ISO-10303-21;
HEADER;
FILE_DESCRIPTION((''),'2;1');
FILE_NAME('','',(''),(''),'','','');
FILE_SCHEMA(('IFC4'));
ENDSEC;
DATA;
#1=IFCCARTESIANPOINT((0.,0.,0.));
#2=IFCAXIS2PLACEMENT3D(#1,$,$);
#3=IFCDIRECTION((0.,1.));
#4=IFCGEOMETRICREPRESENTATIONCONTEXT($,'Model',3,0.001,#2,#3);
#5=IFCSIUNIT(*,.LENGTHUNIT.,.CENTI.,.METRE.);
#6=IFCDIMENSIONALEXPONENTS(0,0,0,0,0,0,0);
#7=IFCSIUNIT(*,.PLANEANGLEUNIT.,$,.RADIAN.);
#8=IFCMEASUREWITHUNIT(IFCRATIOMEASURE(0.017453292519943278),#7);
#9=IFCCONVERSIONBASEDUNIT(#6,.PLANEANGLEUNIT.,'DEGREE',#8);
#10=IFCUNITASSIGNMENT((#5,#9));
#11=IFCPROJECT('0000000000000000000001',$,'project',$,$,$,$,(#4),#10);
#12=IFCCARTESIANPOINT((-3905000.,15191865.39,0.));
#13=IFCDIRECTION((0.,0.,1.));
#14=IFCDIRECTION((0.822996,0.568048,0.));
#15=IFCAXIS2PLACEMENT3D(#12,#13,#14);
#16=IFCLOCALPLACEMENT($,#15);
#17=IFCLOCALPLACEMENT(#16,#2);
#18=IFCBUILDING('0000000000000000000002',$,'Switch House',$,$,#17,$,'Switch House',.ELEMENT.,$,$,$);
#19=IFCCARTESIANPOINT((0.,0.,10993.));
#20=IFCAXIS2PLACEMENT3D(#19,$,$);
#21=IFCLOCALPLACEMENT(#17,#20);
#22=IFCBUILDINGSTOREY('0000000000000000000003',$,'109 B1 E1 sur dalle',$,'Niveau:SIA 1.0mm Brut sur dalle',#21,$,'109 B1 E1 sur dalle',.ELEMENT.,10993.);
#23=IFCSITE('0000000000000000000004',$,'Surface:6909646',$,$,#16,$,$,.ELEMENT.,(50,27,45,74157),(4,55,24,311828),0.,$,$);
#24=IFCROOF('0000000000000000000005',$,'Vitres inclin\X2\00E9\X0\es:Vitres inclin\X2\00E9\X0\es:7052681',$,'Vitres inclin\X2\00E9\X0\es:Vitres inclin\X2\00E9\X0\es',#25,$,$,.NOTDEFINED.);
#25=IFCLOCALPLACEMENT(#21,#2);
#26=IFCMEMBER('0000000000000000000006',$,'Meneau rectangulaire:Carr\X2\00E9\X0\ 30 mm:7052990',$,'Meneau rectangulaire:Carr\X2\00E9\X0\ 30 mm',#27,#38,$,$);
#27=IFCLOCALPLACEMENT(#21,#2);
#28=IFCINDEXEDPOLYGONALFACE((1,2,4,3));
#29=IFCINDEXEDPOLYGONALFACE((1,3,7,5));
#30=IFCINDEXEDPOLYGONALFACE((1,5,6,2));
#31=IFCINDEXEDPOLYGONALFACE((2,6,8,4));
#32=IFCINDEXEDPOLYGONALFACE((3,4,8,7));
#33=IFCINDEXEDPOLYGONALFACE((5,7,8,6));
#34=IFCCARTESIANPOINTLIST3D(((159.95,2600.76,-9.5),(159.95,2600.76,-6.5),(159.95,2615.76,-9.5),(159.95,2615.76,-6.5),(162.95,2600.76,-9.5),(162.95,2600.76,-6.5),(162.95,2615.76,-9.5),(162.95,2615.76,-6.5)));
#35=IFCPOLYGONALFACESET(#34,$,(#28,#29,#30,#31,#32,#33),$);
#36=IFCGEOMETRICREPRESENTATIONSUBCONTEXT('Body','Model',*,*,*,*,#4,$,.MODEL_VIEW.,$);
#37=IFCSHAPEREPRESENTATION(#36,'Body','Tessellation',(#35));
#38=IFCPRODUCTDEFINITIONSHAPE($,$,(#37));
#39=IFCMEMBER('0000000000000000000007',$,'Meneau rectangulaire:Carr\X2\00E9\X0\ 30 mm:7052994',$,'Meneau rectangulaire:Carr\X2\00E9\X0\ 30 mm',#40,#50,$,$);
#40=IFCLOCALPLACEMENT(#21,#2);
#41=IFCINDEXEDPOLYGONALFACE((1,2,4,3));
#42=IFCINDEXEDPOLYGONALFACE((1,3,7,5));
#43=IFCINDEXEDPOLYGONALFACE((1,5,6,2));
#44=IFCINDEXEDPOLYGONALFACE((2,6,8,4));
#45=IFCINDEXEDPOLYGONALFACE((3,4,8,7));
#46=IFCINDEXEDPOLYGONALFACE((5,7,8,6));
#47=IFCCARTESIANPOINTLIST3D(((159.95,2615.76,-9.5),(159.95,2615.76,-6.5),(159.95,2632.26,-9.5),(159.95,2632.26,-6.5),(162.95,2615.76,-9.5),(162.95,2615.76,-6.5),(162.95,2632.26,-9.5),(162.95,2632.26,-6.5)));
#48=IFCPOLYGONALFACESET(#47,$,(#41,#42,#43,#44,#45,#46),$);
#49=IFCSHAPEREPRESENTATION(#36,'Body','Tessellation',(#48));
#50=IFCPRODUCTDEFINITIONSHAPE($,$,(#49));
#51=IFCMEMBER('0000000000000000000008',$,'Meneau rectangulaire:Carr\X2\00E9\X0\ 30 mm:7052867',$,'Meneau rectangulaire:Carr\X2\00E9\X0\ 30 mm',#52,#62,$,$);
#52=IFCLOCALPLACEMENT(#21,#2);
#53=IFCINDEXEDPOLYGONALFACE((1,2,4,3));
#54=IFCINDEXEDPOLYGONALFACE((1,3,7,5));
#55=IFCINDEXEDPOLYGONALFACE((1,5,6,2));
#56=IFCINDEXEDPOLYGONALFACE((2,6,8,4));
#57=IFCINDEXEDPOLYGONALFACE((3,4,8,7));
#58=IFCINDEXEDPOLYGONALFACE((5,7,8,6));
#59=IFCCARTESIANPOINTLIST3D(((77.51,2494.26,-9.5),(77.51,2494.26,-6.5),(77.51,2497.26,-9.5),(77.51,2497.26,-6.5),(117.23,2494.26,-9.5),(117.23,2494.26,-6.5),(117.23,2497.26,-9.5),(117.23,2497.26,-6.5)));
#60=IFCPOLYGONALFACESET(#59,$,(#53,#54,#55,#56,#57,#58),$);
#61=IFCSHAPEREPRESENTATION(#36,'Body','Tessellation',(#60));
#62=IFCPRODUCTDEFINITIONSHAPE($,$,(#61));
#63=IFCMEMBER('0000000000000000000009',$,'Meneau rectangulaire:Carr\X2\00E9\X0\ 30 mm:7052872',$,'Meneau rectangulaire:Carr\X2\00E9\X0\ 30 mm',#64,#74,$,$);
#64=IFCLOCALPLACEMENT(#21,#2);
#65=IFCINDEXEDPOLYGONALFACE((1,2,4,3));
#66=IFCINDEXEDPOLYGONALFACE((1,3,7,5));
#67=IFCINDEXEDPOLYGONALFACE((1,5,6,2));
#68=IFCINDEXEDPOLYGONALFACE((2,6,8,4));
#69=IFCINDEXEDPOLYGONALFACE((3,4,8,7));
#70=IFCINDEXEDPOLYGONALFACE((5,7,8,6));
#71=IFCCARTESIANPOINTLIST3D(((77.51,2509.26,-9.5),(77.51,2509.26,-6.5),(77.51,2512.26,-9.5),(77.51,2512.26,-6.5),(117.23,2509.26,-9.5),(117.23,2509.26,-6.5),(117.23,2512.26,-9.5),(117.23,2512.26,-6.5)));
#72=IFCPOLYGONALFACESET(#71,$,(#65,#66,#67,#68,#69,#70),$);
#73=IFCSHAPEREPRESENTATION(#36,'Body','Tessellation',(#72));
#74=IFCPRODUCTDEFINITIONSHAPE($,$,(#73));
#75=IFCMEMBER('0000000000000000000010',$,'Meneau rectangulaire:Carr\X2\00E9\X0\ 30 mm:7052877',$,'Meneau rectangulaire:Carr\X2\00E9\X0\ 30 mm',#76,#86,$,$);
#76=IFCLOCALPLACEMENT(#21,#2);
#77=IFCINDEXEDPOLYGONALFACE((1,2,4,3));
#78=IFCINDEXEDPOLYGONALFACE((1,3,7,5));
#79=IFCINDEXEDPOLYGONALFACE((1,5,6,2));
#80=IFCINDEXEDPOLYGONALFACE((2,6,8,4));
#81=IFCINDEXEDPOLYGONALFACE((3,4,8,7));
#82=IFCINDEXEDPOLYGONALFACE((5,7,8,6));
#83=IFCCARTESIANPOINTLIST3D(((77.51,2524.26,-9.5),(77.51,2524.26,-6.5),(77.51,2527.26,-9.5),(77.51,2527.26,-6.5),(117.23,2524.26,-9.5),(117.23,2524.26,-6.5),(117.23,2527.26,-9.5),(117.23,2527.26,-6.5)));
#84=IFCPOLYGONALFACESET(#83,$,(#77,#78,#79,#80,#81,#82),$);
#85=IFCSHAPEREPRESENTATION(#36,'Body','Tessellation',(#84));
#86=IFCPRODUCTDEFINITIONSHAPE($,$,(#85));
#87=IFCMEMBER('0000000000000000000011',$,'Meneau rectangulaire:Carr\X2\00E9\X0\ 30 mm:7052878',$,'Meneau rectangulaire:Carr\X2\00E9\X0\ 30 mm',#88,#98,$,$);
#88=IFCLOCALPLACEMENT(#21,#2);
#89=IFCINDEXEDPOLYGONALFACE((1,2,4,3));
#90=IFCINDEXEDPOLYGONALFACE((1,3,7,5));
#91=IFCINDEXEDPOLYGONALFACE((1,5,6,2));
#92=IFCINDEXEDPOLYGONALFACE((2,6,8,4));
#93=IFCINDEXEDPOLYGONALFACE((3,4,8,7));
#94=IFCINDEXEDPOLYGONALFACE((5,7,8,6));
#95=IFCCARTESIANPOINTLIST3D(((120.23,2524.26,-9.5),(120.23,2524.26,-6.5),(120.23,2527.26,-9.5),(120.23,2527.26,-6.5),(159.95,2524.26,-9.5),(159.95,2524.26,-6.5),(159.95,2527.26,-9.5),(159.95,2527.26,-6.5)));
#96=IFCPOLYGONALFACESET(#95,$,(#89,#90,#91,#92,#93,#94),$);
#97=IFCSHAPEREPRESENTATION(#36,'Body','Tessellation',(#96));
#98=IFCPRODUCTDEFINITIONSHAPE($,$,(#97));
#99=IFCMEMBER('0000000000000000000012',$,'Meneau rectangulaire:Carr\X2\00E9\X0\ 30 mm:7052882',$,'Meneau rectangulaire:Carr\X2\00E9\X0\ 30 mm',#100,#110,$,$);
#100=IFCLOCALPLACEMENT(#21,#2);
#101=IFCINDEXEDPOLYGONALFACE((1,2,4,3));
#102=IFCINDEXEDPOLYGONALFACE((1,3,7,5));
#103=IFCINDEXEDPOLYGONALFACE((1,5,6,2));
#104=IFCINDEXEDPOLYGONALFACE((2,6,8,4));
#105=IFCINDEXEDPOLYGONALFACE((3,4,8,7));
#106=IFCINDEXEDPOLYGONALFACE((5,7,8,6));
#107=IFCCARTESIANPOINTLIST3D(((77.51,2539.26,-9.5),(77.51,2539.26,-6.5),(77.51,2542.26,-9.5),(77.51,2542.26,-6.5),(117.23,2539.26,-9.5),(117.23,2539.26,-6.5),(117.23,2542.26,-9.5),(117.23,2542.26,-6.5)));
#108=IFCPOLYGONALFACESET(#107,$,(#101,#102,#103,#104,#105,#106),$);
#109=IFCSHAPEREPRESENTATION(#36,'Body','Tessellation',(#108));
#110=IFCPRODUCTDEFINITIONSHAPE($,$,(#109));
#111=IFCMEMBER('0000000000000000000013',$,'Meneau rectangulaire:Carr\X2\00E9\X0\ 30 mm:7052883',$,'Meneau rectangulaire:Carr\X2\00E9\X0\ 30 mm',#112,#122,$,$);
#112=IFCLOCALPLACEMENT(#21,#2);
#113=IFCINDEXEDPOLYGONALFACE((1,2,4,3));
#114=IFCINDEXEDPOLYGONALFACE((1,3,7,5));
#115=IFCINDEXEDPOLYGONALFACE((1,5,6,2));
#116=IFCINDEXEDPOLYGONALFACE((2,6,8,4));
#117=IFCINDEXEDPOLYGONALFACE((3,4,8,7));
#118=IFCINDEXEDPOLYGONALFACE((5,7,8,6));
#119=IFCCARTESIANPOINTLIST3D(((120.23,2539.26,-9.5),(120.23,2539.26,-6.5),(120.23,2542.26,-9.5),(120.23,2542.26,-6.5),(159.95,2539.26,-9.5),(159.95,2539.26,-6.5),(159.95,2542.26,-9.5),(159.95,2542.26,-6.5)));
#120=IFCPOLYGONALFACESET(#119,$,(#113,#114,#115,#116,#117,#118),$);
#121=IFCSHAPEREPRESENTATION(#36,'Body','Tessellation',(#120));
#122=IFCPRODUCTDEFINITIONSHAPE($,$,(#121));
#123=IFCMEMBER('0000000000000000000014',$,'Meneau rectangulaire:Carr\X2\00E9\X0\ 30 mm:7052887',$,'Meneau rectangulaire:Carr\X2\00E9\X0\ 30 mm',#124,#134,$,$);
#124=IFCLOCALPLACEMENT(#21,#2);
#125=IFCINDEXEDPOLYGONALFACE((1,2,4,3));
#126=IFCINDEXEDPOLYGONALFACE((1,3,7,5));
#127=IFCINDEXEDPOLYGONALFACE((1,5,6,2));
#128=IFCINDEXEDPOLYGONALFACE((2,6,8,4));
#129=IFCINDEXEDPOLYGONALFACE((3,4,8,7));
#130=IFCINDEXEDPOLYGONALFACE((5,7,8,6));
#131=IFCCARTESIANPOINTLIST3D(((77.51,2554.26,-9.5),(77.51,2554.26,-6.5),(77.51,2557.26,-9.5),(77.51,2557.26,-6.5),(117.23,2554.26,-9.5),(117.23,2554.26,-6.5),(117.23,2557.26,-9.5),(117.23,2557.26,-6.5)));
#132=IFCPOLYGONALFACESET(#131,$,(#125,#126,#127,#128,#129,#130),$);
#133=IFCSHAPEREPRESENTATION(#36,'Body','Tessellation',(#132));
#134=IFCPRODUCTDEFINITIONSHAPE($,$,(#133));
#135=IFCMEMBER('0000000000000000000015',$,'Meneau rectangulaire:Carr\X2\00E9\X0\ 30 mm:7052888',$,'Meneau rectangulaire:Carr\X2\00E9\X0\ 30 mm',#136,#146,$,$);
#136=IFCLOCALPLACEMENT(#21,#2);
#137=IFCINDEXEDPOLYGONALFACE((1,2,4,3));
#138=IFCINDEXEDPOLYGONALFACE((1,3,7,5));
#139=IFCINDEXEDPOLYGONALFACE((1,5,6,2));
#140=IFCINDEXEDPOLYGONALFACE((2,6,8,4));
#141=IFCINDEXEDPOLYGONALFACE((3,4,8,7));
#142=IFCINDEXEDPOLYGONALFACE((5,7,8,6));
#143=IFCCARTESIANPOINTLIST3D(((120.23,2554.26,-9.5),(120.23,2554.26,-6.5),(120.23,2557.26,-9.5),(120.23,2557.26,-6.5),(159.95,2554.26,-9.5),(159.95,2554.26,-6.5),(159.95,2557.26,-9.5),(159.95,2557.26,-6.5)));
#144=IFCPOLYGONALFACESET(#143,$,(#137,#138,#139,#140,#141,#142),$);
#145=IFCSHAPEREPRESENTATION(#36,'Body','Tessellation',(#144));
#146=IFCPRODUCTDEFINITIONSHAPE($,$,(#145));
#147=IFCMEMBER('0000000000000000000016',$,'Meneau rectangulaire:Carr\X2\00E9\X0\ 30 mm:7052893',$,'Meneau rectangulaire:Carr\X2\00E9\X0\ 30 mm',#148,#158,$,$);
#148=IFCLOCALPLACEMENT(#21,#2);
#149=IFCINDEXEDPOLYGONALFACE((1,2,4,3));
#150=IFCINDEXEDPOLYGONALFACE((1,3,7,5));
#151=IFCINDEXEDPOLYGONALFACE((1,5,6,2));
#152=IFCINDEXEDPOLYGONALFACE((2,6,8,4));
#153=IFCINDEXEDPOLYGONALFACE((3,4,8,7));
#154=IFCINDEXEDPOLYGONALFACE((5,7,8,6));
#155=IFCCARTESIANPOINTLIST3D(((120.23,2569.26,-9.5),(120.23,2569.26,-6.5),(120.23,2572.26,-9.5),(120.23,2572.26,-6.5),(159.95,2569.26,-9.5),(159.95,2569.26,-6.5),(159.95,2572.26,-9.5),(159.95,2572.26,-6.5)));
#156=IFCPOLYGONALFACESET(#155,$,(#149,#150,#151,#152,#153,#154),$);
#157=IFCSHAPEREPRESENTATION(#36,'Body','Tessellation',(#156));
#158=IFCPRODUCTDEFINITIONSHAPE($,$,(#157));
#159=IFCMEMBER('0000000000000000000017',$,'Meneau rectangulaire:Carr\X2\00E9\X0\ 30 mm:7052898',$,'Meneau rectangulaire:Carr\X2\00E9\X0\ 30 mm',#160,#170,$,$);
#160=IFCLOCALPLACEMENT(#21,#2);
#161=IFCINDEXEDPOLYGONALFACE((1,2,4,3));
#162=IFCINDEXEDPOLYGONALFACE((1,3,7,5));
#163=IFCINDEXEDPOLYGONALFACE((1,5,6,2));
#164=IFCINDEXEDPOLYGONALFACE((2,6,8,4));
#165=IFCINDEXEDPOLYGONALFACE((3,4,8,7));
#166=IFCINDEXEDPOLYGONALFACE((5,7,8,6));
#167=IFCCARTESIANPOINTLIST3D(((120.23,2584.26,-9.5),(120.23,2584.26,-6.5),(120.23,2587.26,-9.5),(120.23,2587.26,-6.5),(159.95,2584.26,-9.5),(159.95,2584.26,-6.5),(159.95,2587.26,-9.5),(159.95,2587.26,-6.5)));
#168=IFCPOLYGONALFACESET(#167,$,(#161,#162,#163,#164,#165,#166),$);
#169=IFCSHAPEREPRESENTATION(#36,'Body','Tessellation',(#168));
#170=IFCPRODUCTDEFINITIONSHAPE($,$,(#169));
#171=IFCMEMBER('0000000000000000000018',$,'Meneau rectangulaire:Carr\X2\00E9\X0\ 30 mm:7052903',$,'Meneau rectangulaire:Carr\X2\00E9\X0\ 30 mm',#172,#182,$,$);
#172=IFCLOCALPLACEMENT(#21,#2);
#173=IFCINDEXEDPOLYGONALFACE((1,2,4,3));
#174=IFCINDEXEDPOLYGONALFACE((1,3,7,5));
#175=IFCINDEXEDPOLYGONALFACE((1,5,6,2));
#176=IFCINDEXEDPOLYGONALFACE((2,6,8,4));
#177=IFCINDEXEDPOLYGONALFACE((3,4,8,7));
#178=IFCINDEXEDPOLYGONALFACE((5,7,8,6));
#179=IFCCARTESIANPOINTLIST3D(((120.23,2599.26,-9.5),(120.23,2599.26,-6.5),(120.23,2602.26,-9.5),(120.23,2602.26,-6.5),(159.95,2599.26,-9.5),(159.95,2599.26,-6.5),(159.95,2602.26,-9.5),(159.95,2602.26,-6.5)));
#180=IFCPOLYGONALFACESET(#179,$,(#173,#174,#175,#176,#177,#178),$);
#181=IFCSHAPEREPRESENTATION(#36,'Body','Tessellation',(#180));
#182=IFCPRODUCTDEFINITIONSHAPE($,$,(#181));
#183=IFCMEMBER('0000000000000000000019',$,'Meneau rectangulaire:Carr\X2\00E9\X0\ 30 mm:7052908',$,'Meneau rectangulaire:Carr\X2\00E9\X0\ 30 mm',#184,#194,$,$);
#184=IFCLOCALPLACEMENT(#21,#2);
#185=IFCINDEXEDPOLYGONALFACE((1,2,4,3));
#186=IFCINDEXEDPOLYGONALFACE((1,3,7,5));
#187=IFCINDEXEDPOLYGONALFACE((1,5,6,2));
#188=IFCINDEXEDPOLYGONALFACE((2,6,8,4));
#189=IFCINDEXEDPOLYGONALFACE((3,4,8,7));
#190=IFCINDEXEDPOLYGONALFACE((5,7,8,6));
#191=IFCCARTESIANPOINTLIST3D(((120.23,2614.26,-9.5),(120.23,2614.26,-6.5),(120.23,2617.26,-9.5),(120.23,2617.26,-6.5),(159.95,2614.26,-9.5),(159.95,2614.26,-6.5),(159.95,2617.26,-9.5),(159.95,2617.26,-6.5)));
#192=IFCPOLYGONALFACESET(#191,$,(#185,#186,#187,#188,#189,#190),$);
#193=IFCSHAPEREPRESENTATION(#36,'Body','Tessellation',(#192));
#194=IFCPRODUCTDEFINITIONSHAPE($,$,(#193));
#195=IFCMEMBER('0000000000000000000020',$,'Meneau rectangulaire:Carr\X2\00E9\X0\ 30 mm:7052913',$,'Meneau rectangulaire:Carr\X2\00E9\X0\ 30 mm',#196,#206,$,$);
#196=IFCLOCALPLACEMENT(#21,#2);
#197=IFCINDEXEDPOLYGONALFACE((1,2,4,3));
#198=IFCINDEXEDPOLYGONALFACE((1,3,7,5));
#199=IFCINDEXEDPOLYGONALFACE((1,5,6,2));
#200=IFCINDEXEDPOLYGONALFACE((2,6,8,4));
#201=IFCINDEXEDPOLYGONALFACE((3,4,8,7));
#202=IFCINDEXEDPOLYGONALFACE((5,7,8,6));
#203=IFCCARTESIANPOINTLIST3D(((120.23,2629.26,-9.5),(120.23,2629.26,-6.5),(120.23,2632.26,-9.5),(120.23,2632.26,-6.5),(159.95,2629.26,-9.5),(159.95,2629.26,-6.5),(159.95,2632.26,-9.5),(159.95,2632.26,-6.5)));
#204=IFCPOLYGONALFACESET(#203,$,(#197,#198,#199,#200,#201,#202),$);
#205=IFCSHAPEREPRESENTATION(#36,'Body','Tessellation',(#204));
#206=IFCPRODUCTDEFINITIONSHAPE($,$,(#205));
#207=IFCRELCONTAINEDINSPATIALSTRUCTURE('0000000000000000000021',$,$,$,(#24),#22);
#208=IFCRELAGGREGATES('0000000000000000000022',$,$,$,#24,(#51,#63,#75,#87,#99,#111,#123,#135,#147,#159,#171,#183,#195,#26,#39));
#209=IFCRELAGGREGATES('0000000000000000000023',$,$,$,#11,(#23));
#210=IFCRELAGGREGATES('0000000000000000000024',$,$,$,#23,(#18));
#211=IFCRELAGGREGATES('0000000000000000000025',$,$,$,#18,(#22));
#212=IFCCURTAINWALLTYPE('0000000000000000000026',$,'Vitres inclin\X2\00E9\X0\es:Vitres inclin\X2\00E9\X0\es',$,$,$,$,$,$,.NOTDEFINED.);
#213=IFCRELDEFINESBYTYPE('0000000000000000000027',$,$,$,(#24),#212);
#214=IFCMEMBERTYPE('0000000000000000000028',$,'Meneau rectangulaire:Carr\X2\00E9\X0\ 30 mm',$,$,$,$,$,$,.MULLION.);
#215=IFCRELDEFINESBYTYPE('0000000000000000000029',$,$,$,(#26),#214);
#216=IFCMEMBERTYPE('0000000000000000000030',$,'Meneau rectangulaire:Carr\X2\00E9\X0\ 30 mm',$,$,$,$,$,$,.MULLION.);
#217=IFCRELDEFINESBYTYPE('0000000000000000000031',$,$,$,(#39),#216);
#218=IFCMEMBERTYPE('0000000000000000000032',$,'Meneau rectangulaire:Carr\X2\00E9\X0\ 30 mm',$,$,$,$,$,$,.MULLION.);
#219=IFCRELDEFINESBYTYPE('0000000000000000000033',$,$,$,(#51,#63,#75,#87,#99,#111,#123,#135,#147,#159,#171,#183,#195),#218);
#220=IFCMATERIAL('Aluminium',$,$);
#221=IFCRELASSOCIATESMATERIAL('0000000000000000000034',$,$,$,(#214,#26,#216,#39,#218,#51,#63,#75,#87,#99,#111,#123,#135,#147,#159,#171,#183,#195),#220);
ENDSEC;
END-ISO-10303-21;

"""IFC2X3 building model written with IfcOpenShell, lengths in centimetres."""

from ifc_helpers import new_model, entity, si_unit, converted_unit, direction, frame, origin, origin_2d_with_axis, place, context, subcontext, project, spatial, rectangle, extrude, source, transform, mapped, material, type_object, type_shapes, element, aggregate, save


model = new_model("IFC2X3")

# Units and contexts
model_context = context("Model", 3, precision=0.001, world=origin(), true_north=direction((0.0, 1.0)))
body_context = subcontext(model_context, "Body", "Model", "MODEL_VIEW")
ifc_project = project(units=[si_unit("LENGTHUNIT", "METRE", prefix="CENTI"), converted_unit("PLANEANGLEUNIT", "DEGREE", entity("IfcRatioMeasure", 0.017453292519943278), si_unit("PLANEANGLEUNIT", "RADIAN"), dimensions=[0, 0, 0, 0, 0, 0, 0])], contexts=[model_context])

# Site, building, storey
site_placement = place(None, frame((-3905000.0, 15191865.39, 0.0), z_axis=(0.0, 0.0, 1.0), x_axis=(0.822996, 0.568048, 0.0)))
site = spatial("IfcSite", under=ifc_project, at=site_placement, Name="Surface:6909646", CompositionType="ELEMENT", RefLatitude=(50, 27, 45, 74157), RefLongitude=(4, 55, 24, 311828), RefElevation=0.0)
building_placement = place(site_placement, origin())
building = spatial("IfcBuilding", under=site, at=building_placement, Name="Switch House", LongName="Switch House", CompositionType="ELEMENT")
storey_placement = place(building_placement, frame((0.0, 0.0, 10993.0)))
storey = spatial("IfcBuildingStorey", under=building, at=storey_placement, Name="109 B1 E1 sur dalle", ObjectType="Niveau:SIA 1.0mm Brut sur dalle", LongName="109 B1 E1 sur dalle", CompositionType="ELEMENT", Elevation=10993.0)

# Roof, members
curtain_wall_type = type_object("IfcCurtainWallType", Name="Vitres inclinées:Vitres inclinées", PredefinedType="NOTDEFINED")
roof_placement = place(storey_placement, frame((0.0, 0.0, -10993.0)))
roof = element("IfcRoof", 1, at=roof_placement, inside=storey, type_object=curtain_wall_type, Name="Vitres inclinées:Vitres inclinées:7052681", ObjectType="Vitres inclinées:Vitres inclinées", ShapeType="NOTDEFINED")
ifc_material = material(Name="Aluminium")
member_type_1 = type_object("IfcMemberType", Name="Meneau rectangulaire:Carré 30 mm", PredefinedType="MULLION", material=ifc_material)
shared_shape_1 = source(origin(), body_context, "Body", "SweptSolid", [
    extrude(rectangle(XDim=3.0, YDim=3.0, at=origin_2d_with_axis()), frame((0.0, 0.0, -15.0), z_axis=(0.0, 0.0, 1.0), x_axis=(0.0, -1.0, 0.0)), (0.0, 0.0, 1.0), 15.0),
])
type_shapes(member_type_1, [shared_shape_1])
member_1_placement = place(roof_placement, frame((161.45, 2615.76, 10985.0), z_axis=(0.0, 1.0, 0.0), x_axis=(1.0, 0.0, 0.0)))
member_1 = element("IfcMember", 2, at=member_1_placement, type_object=member_type_1, material=ifc_material, Name="Meneau rectangulaire:Carré 30 mm:7052990", ObjectType="Meneau rectangulaire:Carré 30 mm", context=body_context, shape_type="MappedRepresentation", body=[
    mapped(shared_shape_1, transform((0.0, 0.0, 0.0), scale=1.0)),
])
member_type_2 = type_object("IfcMemberType", Name="Meneau rectangulaire:Carré 30 mm", PredefinedType="MULLION", material=ifc_material)
shared_shape_2 = source(origin(), body_context, "Body", "SweptSolid", [
    extrude(rectangle(XDim=3.0, YDim=3.0, at=origin_2d_with_axis()), frame((0.0, 0.0, -16.5), z_axis=(0.0, 0.0, 1.0), x_axis=(0.0, -1.0, 0.0)), (0.0, 0.0, 1.0), 16.5),
])
type_shapes(member_type_2, [shared_shape_2])
member_2_placement = place(roof_placement, frame((161.45, 2632.26, 10985.0), z_axis=(0.0, 1.0, 0.0), x_axis=(1.0, 0.0, 0.0)))
member_2 = element("IfcMember", 3, at=member_2_placement, type_object=member_type_2, material=ifc_material, Name="Meneau rectangulaire:Carré 30 mm:7052994", ObjectType="Meneau rectangulaire:Carré 30 mm", context=body_context, shape_type="MappedRepresentation", body=[
    mapped(shared_shape_2, transform((0.0, 0.0, 0.0), scale=1.0)),
])
member_type_3 = type_object("IfcMemberType", Name="Meneau rectangulaire:Carré 30 mm", PredefinedType="MULLION", material=ifc_material)
shared_shape_3 = source(origin(), body_context, "Body", "SweptSolid", [
    extrude(rectangle(XDim=3.0, YDim=3.0, at=origin_2d_with_axis()), frame((0.0, 0.0, -39.72), z_axis=(0.0, 0.0, 1.0), x_axis=(0.0, -1.0, 0.0)), (0.0, 0.0, 1.0), 39.72),
])
type_shapes(member_type_3, [shared_shape_3])
member_3_placement = place(roof_placement, frame((77.51, 2495.76, 10985.0), z_axis=(-1.0, 0.0, 0.0), x_axis=(0.0, 1.0, 0.0)))
member_3 = element("IfcMember", 4, at=member_3_placement, type_object=member_type_3, material=ifc_material, Name="Meneau rectangulaire:Carré 30 mm:7052867", ObjectType="Meneau rectangulaire:Carré 30 mm", context=body_context, shape_type="MappedRepresentation", body=[
    mapped(shared_shape_3, transform((0.0, 0.0, 0.0), scale=1.0)),
])
member_4_placement = place(roof_placement, frame((77.51, 2510.76, 10985.0), z_axis=(-1.0, 0.0, 0.0), x_axis=(0.0, 1.0, 0.0)))
member_4 = element("IfcMember", 5, at=member_4_placement, type_object=member_type_3, material=ifc_material, Name="Meneau rectangulaire:Carré 30 mm:7052872", ObjectType="Meneau rectangulaire:Carré 30 mm", context=body_context, shape_type="MappedRepresentation", body=[
    mapped(shared_shape_3, transform((0.0, 0.0, 0.0), scale=1.0)),
])
member_5_placement = place(roof_placement, frame((77.51, 2525.76, 10985.0), z_axis=(-1.0, 0.0, 0.0), x_axis=(0.0, 1.0, 0.0)))
member_5 = element("IfcMember", 6, at=member_5_placement, type_object=member_type_3, material=ifc_material, Name="Meneau rectangulaire:Carré 30 mm:7052877", ObjectType="Meneau rectangulaire:Carré 30 mm", context=body_context, shape_type="MappedRepresentation", body=[
    mapped(shared_shape_3, transform((0.0, 0.0, 0.0), scale=1.0)),
])
member_6_placement = place(roof_placement, frame((120.23, 2525.76, 10985.0), z_axis=(-1.0, 0.0, 0.0), x_axis=(0.0, 1.0, 0.0)))
member_6 = element("IfcMember", 7, at=member_6_placement, type_object=member_type_3, material=ifc_material, Name="Meneau rectangulaire:Carré 30 mm:7052878", ObjectType="Meneau rectangulaire:Carré 30 mm", context=body_context, shape_type="MappedRepresentation", body=[
    mapped(shared_shape_3, transform((0.0, 0.0, 0.0), scale=1.0)),
])
member_7_placement = place(roof_placement, frame((77.51, 2540.76, 10985.0), z_axis=(-1.0, 0.0, 0.0), x_axis=(0.0, 1.0, 0.0)))
member_7 = element("IfcMember", 8, at=member_7_placement, type_object=member_type_3, material=ifc_material, Name="Meneau rectangulaire:Carré 30 mm:7052882", ObjectType="Meneau rectangulaire:Carré 30 mm", context=body_context, shape_type="MappedRepresentation", body=[
    mapped(shared_shape_3, transform((0.0, 0.0, 0.0), scale=1.0)),
])
member_8_placement = place(roof_placement, frame((120.23, 2540.76, 10985.0), z_axis=(-1.0, 0.0, 0.0), x_axis=(0.0, 1.0, 0.0)))
member_8 = element("IfcMember", 9, at=member_8_placement, type_object=member_type_3, material=ifc_material, Name="Meneau rectangulaire:Carré 30 mm:7052883", ObjectType="Meneau rectangulaire:Carré 30 mm", context=body_context, shape_type="MappedRepresentation", body=[
    mapped(shared_shape_3, transform((0.0, 0.0, 0.0), scale=1.0)),
])
member_9_placement = place(roof_placement, frame((77.51, 2555.76, 10985.0), z_axis=(-1.0, 0.0, 0.0), x_axis=(0.0, 1.0, 0.0)))
member_9 = element("IfcMember", 10, at=member_9_placement, type_object=member_type_3, material=ifc_material, Name="Meneau rectangulaire:Carré 30 mm:7052887", ObjectType="Meneau rectangulaire:Carré 30 mm", context=body_context, shape_type="MappedRepresentation", body=[
    mapped(shared_shape_3, transform((0.0, 0.0, 0.0), scale=1.0)),
])
member_10_placement = place(roof_placement, frame((120.23, 2555.76, 10985.0), z_axis=(-1.0, 0.0, 0.0), x_axis=(0.0, 1.0, 0.0)))
member_10 = element("IfcMember", 11, at=member_10_placement, type_object=member_type_3, material=ifc_material, Name="Meneau rectangulaire:Carré 30 mm:7052888", ObjectType="Meneau rectangulaire:Carré 30 mm", context=body_context, shape_type="MappedRepresentation", body=[
    mapped(shared_shape_3, transform((0.0, 0.0, 0.0), scale=1.0)),
])
member_11_placement = place(roof_placement, frame((120.23, 2570.76, 10985.0), z_axis=(-1.0, 0.0, 0.0), x_axis=(0.0, 1.0, 0.0)))
member_11 = element("IfcMember", 12, at=member_11_placement, type_object=member_type_3, material=ifc_material, Name="Meneau rectangulaire:Carré 30 mm:7052893", ObjectType="Meneau rectangulaire:Carré 30 mm", context=body_context, shape_type="MappedRepresentation", body=[
    mapped(shared_shape_3, transform((0.0, 0.0, 0.0), scale=1.0)),
])
member_12_placement = place(roof_placement, frame((120.23, 2585.76, 10985.0), z_axis=(-1.0, 0.0, 0.0), x_axis=(0.0, 1.0, 0.0)))
member_12 = element("IfcMember", 13, at=member_12_placement, type_object=member_type_3, material=ifc_material, Name="Meneau rectangulaire:Carré 30 mm:7052898", ObjectType="Meneau rectangulaire:Carré 30 mm", context=body_context, shape_type="MappedRepresentation", body=[
    mapped(shared_shape_3, transform((0.0, 0.0, 0.0), scale=1.0)),
])
member_13_placement = place(roof_placement, frame((120.23, 2600.76, 10985.0), z_axis=(-1.0, 0.0, 0.0), x_axis=(0.0, 1.0, 0.0)))
member_13 = element("IfcMember", 14, at=member_13_placement, type_object=member_type_3, material=ifc_material, Name="Meneau rectangulaire:Carré 30 mm:7052903", ObjectType="Meneau rectangulaire:Carré 30 mm", context=body_context, shape_type="MappedRepresentation", body=[
    mapped(shared_shape_3, transform((0.0, 0.0, 0.0), scale=1.0)),
])
member_14_placement = place(roof_placement, frame((120.23, 2615.76, 10985.0), z_axis=(-1.0, 0.0, 0.0), x_axis=(0.0, 1.0, 0.0)))
member_14 = element("IfcMember", 15, at=member_14_placement, type_object=member_type_3, material=ifc_material, Name="Meneau rectangulaire:Carré 30 mm:7052908", ObjectType="Meneau rectangulaire:Carré 30 mm", context=body_context, shape_type="MappedRepresentation", body=[
    mapped(shared_shape_3, transform((0.0, 0.0, 0.0), scale=1.0)),
])
member_15_placement = place(roof_placement, frame((120.23, 2630.76, 10985.0), z_axis=(-1.0, 0.0, 0.0), x_axis=(0.0, 1.0, 0.0)))
member_15 = element("IfcMember", 16, at=member_15_placement, type_object=member_type_3, material=ifc_material, Name="Meneau rectangulaire:Carré 30 mm:7052913", ObjectType="Meneau rectangulaire:Carré 30 mm", context=body_context, shape_type="MappedRepresentation", body=[
    mapped(shared_shape_3, transform((0.0, 0.0, 0.0), scale=1.0)),
])
aggregate(roof, [member_3, member_4, member_5, member_6, member_7, member_8, member_9, member_10, member_11, member_12, member_13, member_14, member_15, member_1, member_2])

save(model, "model.ifc")
